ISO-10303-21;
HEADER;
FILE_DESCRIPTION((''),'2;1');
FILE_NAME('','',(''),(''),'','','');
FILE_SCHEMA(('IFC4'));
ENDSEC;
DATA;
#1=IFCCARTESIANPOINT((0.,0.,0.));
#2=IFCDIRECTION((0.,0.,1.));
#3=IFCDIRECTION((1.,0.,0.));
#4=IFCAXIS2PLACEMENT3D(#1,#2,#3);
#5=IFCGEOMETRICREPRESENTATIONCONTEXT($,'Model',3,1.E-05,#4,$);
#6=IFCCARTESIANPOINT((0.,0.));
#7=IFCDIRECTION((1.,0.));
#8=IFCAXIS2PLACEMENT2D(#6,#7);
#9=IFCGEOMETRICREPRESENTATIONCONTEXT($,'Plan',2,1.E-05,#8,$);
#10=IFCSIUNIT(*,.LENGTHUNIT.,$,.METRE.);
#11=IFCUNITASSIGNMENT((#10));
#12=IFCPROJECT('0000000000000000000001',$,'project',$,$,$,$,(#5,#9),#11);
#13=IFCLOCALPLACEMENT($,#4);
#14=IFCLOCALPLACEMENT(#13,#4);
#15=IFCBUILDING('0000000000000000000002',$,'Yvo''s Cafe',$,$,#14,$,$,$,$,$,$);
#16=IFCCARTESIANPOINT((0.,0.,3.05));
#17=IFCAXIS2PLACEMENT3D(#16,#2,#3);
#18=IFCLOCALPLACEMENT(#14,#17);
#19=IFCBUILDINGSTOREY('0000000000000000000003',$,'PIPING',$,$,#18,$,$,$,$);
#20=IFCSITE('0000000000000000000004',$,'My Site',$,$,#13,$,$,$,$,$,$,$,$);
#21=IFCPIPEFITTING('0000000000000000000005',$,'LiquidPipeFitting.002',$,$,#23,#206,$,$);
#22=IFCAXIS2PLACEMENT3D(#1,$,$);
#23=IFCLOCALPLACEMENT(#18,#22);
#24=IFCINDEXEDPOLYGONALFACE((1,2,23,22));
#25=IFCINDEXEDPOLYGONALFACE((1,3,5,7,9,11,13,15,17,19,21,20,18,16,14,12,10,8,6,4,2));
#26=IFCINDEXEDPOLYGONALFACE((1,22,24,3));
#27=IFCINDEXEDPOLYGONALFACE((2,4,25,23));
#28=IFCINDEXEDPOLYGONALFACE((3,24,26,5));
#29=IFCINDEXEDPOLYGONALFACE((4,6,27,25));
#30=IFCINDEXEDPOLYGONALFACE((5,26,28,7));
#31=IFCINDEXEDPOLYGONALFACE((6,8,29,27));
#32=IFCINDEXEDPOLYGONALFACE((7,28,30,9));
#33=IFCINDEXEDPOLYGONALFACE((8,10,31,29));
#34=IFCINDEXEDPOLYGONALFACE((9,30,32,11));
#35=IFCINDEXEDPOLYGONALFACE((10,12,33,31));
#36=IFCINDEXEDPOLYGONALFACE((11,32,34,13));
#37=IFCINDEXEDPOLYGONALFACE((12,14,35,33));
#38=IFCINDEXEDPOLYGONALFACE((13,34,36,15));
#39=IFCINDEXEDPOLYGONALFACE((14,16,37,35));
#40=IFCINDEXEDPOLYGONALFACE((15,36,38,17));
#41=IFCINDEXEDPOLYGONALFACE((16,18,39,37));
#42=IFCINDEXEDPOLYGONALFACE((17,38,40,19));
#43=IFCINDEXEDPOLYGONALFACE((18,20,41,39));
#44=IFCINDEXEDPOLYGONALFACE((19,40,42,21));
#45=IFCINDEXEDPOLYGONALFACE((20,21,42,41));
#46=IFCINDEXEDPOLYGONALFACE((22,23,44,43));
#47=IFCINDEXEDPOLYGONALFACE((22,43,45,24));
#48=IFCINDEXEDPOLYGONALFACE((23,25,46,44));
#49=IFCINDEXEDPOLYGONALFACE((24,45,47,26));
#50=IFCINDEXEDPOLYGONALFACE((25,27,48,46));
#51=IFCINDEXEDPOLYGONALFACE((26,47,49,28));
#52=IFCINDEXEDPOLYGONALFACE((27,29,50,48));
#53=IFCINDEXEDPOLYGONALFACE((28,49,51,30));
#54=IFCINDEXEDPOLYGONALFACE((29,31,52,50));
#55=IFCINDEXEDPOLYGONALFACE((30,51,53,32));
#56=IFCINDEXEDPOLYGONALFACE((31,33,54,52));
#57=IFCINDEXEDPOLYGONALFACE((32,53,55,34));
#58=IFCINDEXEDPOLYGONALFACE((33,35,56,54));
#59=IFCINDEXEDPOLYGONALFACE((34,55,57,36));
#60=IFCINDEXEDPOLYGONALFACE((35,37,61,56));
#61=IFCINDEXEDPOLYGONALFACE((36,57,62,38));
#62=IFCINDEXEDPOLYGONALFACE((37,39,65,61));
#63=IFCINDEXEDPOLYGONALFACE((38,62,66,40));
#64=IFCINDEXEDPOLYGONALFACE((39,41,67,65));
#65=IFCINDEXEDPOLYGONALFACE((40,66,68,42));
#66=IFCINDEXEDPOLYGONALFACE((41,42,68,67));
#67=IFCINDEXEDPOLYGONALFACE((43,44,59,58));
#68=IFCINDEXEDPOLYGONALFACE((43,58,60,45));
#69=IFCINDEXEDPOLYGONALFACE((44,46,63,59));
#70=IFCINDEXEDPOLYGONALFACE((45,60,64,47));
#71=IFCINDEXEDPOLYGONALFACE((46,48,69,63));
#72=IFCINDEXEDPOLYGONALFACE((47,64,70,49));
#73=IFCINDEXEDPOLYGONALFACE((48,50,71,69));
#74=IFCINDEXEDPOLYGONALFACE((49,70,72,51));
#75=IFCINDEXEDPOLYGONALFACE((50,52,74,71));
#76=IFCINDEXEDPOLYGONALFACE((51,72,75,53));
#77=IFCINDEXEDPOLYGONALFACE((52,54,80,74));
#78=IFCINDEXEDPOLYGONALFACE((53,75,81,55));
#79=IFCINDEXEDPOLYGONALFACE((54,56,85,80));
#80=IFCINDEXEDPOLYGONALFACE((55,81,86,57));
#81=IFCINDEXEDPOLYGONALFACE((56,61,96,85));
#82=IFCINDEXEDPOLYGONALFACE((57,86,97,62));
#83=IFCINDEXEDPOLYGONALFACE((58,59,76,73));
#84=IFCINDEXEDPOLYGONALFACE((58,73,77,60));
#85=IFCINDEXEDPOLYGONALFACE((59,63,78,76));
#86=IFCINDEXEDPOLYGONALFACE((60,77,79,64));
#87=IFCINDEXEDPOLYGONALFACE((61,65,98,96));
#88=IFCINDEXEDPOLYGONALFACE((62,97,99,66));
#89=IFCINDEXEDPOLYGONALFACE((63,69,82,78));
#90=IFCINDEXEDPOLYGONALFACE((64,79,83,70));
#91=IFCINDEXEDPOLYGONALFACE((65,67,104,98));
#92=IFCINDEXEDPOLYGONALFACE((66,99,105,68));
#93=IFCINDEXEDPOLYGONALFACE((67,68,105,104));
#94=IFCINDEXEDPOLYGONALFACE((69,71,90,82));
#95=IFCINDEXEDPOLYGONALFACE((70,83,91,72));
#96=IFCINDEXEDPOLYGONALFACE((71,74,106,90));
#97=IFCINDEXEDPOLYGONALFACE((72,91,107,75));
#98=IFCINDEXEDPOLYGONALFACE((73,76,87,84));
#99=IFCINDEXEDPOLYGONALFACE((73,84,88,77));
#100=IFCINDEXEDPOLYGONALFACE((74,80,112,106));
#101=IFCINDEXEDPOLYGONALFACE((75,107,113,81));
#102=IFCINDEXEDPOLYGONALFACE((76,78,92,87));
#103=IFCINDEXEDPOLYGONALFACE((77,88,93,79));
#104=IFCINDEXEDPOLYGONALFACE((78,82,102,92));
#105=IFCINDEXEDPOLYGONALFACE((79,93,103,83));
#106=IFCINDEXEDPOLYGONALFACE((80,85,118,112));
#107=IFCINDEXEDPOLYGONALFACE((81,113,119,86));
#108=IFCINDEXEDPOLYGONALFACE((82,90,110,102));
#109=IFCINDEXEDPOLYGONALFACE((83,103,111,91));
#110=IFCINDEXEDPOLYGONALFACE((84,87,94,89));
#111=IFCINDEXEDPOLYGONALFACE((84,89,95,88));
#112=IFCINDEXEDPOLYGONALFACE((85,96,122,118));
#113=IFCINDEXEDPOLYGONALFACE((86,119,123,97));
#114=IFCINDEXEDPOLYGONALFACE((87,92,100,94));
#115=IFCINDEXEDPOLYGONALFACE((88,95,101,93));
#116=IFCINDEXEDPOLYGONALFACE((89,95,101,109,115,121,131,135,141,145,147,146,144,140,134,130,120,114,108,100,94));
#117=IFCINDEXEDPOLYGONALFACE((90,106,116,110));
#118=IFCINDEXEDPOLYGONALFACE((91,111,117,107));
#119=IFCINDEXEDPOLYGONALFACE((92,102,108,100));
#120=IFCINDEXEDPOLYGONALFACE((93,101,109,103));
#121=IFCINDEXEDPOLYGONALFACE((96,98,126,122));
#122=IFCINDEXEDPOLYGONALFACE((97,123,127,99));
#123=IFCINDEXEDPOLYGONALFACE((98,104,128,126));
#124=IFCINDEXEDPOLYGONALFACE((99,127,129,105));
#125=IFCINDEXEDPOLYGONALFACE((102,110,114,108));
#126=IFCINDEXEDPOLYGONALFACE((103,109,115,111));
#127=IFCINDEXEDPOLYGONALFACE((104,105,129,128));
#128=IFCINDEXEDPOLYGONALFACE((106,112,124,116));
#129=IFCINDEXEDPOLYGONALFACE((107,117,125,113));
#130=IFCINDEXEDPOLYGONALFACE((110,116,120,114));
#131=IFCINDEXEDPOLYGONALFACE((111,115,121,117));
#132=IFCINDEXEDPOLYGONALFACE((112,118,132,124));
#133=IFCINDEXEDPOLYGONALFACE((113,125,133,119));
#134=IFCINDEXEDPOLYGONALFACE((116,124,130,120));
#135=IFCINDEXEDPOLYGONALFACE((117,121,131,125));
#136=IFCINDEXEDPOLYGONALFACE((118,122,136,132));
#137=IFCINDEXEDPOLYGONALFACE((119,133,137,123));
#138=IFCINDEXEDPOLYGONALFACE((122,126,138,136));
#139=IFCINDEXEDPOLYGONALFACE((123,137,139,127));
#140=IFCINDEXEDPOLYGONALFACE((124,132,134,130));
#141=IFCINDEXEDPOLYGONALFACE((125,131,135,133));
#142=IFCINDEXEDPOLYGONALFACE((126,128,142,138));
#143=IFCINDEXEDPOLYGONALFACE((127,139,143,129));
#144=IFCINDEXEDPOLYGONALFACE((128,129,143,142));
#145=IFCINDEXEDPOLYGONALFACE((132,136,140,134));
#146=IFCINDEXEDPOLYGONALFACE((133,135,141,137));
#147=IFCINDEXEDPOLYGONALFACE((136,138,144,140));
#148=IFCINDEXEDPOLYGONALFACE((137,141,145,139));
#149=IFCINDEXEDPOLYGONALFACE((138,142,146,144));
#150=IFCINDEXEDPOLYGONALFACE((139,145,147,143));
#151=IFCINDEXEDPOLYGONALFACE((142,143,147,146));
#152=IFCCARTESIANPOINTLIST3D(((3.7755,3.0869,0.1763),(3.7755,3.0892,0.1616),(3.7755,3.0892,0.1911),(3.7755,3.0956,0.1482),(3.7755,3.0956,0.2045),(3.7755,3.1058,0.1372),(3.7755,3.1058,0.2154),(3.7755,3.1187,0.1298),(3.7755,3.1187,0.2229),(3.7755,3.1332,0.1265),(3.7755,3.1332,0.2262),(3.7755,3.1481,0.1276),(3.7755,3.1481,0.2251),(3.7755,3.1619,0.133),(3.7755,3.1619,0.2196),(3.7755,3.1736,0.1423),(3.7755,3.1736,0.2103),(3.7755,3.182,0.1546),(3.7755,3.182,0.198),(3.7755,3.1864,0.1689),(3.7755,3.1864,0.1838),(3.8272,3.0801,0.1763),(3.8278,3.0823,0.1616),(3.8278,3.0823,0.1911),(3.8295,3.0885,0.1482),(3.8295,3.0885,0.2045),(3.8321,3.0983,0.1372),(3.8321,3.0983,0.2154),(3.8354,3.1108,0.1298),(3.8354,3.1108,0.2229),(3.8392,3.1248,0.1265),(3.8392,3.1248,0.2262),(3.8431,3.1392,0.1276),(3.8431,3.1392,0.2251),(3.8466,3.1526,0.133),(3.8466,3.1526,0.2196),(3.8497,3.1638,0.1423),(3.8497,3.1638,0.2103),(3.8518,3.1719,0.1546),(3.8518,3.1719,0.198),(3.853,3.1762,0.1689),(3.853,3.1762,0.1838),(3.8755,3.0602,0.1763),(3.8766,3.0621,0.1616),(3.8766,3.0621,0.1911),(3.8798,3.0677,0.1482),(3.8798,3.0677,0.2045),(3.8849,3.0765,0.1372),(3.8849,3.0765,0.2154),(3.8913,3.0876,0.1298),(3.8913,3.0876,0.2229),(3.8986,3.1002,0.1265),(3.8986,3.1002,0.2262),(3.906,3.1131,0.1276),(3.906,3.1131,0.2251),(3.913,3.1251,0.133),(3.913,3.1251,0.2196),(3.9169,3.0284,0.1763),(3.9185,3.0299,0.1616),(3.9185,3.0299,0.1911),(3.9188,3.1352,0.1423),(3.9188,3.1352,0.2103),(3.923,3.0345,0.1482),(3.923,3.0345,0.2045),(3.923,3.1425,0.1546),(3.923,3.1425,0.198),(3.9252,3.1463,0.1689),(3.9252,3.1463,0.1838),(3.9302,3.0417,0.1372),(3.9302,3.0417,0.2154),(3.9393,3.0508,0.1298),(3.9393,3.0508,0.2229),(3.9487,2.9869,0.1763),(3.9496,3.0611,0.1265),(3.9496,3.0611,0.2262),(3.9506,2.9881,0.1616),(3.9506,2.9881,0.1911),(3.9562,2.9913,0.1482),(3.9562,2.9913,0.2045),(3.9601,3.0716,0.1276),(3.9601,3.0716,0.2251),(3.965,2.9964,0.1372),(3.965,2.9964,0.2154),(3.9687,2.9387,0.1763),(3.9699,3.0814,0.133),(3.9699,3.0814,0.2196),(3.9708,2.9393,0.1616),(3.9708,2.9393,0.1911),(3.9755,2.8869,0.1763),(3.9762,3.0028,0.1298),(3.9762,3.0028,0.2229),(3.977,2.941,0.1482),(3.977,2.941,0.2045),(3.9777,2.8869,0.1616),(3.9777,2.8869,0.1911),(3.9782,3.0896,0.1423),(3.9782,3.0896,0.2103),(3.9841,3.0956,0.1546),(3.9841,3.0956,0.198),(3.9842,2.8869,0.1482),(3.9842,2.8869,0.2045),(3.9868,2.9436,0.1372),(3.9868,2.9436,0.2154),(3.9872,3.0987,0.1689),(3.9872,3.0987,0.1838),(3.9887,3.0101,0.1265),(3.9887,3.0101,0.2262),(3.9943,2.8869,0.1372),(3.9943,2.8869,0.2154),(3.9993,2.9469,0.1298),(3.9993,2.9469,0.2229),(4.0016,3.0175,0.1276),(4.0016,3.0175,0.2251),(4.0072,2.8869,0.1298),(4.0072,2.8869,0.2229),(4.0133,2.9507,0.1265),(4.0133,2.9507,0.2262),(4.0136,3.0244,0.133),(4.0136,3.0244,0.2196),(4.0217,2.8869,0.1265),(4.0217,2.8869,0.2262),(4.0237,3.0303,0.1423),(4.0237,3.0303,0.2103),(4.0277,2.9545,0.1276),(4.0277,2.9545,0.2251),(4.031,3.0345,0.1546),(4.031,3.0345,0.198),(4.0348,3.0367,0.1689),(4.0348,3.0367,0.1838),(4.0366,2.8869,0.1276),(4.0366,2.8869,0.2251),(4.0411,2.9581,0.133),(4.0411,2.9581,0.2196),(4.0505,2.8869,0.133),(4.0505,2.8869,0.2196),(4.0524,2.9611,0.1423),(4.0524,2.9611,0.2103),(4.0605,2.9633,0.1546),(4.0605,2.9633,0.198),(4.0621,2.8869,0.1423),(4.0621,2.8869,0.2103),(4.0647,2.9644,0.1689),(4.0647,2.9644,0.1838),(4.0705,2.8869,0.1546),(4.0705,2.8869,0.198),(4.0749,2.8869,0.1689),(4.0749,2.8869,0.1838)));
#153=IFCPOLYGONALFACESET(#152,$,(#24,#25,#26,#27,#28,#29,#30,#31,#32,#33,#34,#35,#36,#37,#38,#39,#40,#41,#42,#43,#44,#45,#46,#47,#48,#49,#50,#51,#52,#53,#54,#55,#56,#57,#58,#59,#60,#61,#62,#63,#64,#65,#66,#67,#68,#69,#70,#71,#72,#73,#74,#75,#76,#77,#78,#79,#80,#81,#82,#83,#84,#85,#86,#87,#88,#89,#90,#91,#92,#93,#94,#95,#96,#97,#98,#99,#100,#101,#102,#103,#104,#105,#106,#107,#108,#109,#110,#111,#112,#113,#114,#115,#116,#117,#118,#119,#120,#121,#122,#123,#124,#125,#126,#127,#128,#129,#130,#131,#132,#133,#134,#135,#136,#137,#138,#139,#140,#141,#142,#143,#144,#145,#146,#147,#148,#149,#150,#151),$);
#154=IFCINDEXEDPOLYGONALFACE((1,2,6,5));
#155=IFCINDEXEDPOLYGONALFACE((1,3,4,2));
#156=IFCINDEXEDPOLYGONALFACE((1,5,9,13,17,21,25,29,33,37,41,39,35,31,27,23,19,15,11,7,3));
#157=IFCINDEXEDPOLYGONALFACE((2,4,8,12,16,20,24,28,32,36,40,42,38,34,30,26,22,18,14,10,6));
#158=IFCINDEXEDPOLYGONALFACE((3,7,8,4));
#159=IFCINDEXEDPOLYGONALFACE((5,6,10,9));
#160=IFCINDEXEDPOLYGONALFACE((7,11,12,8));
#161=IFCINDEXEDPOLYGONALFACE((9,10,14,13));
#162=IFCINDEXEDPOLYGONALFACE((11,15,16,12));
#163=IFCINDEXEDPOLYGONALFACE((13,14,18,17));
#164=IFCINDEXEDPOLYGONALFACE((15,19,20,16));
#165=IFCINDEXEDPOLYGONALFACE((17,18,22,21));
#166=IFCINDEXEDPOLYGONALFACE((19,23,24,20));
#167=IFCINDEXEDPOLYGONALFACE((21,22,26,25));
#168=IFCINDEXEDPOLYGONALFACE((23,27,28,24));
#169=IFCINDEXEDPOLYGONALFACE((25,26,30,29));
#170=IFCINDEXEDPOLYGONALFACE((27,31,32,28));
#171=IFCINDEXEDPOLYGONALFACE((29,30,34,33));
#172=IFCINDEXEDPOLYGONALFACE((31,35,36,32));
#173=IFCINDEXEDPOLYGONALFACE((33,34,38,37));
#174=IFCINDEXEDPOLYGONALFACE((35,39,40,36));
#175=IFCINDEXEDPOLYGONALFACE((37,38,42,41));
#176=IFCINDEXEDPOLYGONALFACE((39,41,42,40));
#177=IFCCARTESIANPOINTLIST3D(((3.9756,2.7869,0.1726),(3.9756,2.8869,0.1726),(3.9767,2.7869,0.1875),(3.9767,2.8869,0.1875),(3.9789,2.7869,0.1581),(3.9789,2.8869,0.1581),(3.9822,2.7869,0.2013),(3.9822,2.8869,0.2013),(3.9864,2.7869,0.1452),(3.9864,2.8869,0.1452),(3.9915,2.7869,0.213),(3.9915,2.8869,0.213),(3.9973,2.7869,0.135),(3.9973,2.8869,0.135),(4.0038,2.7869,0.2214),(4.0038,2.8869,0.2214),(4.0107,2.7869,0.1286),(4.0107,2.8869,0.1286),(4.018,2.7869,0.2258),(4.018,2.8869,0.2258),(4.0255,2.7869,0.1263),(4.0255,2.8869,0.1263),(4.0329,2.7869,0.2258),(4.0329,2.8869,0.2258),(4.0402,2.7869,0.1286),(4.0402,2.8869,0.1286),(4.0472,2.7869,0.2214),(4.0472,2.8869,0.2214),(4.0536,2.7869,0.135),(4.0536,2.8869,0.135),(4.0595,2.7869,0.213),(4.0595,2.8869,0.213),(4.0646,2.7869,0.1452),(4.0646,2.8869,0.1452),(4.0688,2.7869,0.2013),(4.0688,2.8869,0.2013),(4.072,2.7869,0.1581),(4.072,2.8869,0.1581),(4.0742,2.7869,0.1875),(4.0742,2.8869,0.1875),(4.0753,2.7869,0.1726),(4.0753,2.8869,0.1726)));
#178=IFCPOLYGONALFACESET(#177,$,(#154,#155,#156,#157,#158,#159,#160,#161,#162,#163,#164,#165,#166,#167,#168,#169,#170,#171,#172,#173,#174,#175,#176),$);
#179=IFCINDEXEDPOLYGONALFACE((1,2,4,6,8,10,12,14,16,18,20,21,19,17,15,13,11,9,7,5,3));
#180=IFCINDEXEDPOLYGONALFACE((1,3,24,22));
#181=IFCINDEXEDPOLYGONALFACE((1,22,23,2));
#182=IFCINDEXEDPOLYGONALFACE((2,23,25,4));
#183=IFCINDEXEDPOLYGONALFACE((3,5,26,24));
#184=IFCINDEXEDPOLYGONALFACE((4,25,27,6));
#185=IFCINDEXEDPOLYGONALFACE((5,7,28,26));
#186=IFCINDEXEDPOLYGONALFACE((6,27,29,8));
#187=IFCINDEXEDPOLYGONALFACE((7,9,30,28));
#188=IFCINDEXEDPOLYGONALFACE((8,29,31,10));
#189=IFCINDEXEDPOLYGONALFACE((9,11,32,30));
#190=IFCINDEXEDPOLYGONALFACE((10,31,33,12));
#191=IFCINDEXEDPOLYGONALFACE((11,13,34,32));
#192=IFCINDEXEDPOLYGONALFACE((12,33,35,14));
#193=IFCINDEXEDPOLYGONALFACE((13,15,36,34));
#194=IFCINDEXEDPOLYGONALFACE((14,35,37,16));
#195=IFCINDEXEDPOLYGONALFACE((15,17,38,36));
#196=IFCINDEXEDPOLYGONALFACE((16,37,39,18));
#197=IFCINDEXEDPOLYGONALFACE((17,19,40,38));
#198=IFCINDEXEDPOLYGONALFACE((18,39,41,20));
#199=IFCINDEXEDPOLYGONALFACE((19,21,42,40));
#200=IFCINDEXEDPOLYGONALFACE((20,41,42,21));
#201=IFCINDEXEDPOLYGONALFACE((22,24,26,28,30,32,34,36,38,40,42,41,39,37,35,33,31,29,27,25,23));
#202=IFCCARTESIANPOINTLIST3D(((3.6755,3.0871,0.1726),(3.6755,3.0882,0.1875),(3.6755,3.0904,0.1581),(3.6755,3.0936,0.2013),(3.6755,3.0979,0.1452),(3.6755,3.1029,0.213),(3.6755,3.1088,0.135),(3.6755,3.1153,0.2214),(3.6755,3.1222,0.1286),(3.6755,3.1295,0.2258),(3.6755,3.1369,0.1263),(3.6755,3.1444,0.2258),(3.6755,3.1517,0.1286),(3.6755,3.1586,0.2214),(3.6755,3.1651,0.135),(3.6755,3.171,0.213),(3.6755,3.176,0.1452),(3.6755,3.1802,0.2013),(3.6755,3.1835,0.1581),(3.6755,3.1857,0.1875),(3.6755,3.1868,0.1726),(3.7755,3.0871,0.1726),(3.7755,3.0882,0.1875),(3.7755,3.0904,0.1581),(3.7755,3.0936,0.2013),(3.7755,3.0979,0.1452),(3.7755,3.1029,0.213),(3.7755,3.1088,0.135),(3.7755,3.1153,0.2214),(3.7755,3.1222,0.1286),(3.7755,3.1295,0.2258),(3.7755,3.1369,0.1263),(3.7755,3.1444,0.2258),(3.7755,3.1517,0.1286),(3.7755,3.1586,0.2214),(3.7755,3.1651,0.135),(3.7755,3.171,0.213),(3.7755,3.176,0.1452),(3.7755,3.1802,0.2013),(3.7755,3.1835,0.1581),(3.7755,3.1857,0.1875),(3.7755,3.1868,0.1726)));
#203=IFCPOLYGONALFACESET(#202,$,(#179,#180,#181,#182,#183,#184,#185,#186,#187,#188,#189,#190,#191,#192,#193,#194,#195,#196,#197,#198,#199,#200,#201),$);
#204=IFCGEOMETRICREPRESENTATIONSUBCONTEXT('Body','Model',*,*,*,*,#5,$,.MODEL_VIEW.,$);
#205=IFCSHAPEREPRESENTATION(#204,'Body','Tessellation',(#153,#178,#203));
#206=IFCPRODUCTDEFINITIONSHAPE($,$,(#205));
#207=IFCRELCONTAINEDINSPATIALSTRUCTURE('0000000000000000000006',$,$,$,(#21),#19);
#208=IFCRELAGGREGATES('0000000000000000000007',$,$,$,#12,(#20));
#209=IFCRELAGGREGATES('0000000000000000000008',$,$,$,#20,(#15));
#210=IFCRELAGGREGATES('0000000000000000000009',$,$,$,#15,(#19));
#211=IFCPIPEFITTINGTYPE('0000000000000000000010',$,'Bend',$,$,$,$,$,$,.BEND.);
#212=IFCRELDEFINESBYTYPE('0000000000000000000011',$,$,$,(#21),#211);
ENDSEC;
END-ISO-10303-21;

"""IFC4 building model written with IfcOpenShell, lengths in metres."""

from ifc_helpers import new_model, entity, si_unit, frame, origin_with_axes, origin_2d_with_axis, place, context, subcontext, project, spatial, circle, extrude, source, transform, mapped, type_object, type_shapes, element, save


model = new_model("IFC4")

# Units and contexts
model_context = context("Model", 3, precision=1e-05, world=origin_with_axes())
plan_context = context("Plan", 2, precision=1e-05, world=origin_2d_with_axis())
body_context = subcontext(model_context, "Body", "Model", "MODEL_VIEW")
ifc_project = project(units=[si_unit("LENGTHUNIT", "METRE")], contexts=[model_context, plan_context])

# Site, building, storey
site_placement = place(None, origin_with_axes())
site = spatial("IfcSite", under=ifc_project, at=site_placement, Name="My Site")
building_placement = place(site_placement, origin_with_axes())
building = spatial("IfcBuilding", under=site, at=building_placement, Name="Yvo's Cafe")
storey_placement = place(building_placement, frame((0.0, 0.0, 3.05), z_axis=(0.0, 0.0, 1.0), x_axis=(1.0, 0.0, 0.0)))
storey = spatial("IfcBuildingStorey", under=building, at=storey_placement, Name="PIPING")

# Shared definitions
pipe_fitting_type_1 = type_object("IfcPipeFittingType", Name="Bend", PredefinedType="BEND")
shared_shape_1 = source(origin_with_axes(), body_context, "Body", "SolidModel", [
    entity("IfcSweptDiskSolid", entity("IfcIndexedPolyCurve", entity("IfcCartesianPointList3D", [[0.0, 0.0, -0.1], [0.0, -0.0732, -0.2768], [0.0, -0.25, -0.35]]), [entity("IfcArcIndex", [1, 2, 3])]), 0.05),
    extrude(circle(Radius=0.05), origin_with_axes(), (0.0, 0.0, -1.0), 0.1),
    extrude(circle(Radius=0.05), frame((0.0, -0.25, -0.35), z_axis=(0.0, -1.0, 0.0), x_axis=(1.0, 0.0, 0.0)), (0.0, 0.0, 1.0), 0.1),
])
type_shapes(pipe_fitting_type_1, [shared_shape_1])

# Pipe fitting
for number, where, z_axis, x_axis, name in (
    (1, (4.0255, 2.7869, 0.1763), (0.0, -1.0, 0.0), (0.0, 0.0, -1.0), "LiquidPipeFitting.002"),
):
    element("IfcPipeFitting", number, at=place(storey_placement, frame(where, z_axis=z_axis, x_axis=x_axis)), inside=storey, type_object=pipe_fitting_type_1, Name=name, context=body_context, shape_type="MappedRepresentation", body=[
        mapped(shared_shape_1, transform((0.0, 0.0, 0.0), x_axis=(1.0, 0.0, 0.0), y_axis=(0.0, 1.0, 0.0), z_axis=(0.0, 0.0, 1.0), scale=1.0)),
    ])

save(model, "model.ifc")
